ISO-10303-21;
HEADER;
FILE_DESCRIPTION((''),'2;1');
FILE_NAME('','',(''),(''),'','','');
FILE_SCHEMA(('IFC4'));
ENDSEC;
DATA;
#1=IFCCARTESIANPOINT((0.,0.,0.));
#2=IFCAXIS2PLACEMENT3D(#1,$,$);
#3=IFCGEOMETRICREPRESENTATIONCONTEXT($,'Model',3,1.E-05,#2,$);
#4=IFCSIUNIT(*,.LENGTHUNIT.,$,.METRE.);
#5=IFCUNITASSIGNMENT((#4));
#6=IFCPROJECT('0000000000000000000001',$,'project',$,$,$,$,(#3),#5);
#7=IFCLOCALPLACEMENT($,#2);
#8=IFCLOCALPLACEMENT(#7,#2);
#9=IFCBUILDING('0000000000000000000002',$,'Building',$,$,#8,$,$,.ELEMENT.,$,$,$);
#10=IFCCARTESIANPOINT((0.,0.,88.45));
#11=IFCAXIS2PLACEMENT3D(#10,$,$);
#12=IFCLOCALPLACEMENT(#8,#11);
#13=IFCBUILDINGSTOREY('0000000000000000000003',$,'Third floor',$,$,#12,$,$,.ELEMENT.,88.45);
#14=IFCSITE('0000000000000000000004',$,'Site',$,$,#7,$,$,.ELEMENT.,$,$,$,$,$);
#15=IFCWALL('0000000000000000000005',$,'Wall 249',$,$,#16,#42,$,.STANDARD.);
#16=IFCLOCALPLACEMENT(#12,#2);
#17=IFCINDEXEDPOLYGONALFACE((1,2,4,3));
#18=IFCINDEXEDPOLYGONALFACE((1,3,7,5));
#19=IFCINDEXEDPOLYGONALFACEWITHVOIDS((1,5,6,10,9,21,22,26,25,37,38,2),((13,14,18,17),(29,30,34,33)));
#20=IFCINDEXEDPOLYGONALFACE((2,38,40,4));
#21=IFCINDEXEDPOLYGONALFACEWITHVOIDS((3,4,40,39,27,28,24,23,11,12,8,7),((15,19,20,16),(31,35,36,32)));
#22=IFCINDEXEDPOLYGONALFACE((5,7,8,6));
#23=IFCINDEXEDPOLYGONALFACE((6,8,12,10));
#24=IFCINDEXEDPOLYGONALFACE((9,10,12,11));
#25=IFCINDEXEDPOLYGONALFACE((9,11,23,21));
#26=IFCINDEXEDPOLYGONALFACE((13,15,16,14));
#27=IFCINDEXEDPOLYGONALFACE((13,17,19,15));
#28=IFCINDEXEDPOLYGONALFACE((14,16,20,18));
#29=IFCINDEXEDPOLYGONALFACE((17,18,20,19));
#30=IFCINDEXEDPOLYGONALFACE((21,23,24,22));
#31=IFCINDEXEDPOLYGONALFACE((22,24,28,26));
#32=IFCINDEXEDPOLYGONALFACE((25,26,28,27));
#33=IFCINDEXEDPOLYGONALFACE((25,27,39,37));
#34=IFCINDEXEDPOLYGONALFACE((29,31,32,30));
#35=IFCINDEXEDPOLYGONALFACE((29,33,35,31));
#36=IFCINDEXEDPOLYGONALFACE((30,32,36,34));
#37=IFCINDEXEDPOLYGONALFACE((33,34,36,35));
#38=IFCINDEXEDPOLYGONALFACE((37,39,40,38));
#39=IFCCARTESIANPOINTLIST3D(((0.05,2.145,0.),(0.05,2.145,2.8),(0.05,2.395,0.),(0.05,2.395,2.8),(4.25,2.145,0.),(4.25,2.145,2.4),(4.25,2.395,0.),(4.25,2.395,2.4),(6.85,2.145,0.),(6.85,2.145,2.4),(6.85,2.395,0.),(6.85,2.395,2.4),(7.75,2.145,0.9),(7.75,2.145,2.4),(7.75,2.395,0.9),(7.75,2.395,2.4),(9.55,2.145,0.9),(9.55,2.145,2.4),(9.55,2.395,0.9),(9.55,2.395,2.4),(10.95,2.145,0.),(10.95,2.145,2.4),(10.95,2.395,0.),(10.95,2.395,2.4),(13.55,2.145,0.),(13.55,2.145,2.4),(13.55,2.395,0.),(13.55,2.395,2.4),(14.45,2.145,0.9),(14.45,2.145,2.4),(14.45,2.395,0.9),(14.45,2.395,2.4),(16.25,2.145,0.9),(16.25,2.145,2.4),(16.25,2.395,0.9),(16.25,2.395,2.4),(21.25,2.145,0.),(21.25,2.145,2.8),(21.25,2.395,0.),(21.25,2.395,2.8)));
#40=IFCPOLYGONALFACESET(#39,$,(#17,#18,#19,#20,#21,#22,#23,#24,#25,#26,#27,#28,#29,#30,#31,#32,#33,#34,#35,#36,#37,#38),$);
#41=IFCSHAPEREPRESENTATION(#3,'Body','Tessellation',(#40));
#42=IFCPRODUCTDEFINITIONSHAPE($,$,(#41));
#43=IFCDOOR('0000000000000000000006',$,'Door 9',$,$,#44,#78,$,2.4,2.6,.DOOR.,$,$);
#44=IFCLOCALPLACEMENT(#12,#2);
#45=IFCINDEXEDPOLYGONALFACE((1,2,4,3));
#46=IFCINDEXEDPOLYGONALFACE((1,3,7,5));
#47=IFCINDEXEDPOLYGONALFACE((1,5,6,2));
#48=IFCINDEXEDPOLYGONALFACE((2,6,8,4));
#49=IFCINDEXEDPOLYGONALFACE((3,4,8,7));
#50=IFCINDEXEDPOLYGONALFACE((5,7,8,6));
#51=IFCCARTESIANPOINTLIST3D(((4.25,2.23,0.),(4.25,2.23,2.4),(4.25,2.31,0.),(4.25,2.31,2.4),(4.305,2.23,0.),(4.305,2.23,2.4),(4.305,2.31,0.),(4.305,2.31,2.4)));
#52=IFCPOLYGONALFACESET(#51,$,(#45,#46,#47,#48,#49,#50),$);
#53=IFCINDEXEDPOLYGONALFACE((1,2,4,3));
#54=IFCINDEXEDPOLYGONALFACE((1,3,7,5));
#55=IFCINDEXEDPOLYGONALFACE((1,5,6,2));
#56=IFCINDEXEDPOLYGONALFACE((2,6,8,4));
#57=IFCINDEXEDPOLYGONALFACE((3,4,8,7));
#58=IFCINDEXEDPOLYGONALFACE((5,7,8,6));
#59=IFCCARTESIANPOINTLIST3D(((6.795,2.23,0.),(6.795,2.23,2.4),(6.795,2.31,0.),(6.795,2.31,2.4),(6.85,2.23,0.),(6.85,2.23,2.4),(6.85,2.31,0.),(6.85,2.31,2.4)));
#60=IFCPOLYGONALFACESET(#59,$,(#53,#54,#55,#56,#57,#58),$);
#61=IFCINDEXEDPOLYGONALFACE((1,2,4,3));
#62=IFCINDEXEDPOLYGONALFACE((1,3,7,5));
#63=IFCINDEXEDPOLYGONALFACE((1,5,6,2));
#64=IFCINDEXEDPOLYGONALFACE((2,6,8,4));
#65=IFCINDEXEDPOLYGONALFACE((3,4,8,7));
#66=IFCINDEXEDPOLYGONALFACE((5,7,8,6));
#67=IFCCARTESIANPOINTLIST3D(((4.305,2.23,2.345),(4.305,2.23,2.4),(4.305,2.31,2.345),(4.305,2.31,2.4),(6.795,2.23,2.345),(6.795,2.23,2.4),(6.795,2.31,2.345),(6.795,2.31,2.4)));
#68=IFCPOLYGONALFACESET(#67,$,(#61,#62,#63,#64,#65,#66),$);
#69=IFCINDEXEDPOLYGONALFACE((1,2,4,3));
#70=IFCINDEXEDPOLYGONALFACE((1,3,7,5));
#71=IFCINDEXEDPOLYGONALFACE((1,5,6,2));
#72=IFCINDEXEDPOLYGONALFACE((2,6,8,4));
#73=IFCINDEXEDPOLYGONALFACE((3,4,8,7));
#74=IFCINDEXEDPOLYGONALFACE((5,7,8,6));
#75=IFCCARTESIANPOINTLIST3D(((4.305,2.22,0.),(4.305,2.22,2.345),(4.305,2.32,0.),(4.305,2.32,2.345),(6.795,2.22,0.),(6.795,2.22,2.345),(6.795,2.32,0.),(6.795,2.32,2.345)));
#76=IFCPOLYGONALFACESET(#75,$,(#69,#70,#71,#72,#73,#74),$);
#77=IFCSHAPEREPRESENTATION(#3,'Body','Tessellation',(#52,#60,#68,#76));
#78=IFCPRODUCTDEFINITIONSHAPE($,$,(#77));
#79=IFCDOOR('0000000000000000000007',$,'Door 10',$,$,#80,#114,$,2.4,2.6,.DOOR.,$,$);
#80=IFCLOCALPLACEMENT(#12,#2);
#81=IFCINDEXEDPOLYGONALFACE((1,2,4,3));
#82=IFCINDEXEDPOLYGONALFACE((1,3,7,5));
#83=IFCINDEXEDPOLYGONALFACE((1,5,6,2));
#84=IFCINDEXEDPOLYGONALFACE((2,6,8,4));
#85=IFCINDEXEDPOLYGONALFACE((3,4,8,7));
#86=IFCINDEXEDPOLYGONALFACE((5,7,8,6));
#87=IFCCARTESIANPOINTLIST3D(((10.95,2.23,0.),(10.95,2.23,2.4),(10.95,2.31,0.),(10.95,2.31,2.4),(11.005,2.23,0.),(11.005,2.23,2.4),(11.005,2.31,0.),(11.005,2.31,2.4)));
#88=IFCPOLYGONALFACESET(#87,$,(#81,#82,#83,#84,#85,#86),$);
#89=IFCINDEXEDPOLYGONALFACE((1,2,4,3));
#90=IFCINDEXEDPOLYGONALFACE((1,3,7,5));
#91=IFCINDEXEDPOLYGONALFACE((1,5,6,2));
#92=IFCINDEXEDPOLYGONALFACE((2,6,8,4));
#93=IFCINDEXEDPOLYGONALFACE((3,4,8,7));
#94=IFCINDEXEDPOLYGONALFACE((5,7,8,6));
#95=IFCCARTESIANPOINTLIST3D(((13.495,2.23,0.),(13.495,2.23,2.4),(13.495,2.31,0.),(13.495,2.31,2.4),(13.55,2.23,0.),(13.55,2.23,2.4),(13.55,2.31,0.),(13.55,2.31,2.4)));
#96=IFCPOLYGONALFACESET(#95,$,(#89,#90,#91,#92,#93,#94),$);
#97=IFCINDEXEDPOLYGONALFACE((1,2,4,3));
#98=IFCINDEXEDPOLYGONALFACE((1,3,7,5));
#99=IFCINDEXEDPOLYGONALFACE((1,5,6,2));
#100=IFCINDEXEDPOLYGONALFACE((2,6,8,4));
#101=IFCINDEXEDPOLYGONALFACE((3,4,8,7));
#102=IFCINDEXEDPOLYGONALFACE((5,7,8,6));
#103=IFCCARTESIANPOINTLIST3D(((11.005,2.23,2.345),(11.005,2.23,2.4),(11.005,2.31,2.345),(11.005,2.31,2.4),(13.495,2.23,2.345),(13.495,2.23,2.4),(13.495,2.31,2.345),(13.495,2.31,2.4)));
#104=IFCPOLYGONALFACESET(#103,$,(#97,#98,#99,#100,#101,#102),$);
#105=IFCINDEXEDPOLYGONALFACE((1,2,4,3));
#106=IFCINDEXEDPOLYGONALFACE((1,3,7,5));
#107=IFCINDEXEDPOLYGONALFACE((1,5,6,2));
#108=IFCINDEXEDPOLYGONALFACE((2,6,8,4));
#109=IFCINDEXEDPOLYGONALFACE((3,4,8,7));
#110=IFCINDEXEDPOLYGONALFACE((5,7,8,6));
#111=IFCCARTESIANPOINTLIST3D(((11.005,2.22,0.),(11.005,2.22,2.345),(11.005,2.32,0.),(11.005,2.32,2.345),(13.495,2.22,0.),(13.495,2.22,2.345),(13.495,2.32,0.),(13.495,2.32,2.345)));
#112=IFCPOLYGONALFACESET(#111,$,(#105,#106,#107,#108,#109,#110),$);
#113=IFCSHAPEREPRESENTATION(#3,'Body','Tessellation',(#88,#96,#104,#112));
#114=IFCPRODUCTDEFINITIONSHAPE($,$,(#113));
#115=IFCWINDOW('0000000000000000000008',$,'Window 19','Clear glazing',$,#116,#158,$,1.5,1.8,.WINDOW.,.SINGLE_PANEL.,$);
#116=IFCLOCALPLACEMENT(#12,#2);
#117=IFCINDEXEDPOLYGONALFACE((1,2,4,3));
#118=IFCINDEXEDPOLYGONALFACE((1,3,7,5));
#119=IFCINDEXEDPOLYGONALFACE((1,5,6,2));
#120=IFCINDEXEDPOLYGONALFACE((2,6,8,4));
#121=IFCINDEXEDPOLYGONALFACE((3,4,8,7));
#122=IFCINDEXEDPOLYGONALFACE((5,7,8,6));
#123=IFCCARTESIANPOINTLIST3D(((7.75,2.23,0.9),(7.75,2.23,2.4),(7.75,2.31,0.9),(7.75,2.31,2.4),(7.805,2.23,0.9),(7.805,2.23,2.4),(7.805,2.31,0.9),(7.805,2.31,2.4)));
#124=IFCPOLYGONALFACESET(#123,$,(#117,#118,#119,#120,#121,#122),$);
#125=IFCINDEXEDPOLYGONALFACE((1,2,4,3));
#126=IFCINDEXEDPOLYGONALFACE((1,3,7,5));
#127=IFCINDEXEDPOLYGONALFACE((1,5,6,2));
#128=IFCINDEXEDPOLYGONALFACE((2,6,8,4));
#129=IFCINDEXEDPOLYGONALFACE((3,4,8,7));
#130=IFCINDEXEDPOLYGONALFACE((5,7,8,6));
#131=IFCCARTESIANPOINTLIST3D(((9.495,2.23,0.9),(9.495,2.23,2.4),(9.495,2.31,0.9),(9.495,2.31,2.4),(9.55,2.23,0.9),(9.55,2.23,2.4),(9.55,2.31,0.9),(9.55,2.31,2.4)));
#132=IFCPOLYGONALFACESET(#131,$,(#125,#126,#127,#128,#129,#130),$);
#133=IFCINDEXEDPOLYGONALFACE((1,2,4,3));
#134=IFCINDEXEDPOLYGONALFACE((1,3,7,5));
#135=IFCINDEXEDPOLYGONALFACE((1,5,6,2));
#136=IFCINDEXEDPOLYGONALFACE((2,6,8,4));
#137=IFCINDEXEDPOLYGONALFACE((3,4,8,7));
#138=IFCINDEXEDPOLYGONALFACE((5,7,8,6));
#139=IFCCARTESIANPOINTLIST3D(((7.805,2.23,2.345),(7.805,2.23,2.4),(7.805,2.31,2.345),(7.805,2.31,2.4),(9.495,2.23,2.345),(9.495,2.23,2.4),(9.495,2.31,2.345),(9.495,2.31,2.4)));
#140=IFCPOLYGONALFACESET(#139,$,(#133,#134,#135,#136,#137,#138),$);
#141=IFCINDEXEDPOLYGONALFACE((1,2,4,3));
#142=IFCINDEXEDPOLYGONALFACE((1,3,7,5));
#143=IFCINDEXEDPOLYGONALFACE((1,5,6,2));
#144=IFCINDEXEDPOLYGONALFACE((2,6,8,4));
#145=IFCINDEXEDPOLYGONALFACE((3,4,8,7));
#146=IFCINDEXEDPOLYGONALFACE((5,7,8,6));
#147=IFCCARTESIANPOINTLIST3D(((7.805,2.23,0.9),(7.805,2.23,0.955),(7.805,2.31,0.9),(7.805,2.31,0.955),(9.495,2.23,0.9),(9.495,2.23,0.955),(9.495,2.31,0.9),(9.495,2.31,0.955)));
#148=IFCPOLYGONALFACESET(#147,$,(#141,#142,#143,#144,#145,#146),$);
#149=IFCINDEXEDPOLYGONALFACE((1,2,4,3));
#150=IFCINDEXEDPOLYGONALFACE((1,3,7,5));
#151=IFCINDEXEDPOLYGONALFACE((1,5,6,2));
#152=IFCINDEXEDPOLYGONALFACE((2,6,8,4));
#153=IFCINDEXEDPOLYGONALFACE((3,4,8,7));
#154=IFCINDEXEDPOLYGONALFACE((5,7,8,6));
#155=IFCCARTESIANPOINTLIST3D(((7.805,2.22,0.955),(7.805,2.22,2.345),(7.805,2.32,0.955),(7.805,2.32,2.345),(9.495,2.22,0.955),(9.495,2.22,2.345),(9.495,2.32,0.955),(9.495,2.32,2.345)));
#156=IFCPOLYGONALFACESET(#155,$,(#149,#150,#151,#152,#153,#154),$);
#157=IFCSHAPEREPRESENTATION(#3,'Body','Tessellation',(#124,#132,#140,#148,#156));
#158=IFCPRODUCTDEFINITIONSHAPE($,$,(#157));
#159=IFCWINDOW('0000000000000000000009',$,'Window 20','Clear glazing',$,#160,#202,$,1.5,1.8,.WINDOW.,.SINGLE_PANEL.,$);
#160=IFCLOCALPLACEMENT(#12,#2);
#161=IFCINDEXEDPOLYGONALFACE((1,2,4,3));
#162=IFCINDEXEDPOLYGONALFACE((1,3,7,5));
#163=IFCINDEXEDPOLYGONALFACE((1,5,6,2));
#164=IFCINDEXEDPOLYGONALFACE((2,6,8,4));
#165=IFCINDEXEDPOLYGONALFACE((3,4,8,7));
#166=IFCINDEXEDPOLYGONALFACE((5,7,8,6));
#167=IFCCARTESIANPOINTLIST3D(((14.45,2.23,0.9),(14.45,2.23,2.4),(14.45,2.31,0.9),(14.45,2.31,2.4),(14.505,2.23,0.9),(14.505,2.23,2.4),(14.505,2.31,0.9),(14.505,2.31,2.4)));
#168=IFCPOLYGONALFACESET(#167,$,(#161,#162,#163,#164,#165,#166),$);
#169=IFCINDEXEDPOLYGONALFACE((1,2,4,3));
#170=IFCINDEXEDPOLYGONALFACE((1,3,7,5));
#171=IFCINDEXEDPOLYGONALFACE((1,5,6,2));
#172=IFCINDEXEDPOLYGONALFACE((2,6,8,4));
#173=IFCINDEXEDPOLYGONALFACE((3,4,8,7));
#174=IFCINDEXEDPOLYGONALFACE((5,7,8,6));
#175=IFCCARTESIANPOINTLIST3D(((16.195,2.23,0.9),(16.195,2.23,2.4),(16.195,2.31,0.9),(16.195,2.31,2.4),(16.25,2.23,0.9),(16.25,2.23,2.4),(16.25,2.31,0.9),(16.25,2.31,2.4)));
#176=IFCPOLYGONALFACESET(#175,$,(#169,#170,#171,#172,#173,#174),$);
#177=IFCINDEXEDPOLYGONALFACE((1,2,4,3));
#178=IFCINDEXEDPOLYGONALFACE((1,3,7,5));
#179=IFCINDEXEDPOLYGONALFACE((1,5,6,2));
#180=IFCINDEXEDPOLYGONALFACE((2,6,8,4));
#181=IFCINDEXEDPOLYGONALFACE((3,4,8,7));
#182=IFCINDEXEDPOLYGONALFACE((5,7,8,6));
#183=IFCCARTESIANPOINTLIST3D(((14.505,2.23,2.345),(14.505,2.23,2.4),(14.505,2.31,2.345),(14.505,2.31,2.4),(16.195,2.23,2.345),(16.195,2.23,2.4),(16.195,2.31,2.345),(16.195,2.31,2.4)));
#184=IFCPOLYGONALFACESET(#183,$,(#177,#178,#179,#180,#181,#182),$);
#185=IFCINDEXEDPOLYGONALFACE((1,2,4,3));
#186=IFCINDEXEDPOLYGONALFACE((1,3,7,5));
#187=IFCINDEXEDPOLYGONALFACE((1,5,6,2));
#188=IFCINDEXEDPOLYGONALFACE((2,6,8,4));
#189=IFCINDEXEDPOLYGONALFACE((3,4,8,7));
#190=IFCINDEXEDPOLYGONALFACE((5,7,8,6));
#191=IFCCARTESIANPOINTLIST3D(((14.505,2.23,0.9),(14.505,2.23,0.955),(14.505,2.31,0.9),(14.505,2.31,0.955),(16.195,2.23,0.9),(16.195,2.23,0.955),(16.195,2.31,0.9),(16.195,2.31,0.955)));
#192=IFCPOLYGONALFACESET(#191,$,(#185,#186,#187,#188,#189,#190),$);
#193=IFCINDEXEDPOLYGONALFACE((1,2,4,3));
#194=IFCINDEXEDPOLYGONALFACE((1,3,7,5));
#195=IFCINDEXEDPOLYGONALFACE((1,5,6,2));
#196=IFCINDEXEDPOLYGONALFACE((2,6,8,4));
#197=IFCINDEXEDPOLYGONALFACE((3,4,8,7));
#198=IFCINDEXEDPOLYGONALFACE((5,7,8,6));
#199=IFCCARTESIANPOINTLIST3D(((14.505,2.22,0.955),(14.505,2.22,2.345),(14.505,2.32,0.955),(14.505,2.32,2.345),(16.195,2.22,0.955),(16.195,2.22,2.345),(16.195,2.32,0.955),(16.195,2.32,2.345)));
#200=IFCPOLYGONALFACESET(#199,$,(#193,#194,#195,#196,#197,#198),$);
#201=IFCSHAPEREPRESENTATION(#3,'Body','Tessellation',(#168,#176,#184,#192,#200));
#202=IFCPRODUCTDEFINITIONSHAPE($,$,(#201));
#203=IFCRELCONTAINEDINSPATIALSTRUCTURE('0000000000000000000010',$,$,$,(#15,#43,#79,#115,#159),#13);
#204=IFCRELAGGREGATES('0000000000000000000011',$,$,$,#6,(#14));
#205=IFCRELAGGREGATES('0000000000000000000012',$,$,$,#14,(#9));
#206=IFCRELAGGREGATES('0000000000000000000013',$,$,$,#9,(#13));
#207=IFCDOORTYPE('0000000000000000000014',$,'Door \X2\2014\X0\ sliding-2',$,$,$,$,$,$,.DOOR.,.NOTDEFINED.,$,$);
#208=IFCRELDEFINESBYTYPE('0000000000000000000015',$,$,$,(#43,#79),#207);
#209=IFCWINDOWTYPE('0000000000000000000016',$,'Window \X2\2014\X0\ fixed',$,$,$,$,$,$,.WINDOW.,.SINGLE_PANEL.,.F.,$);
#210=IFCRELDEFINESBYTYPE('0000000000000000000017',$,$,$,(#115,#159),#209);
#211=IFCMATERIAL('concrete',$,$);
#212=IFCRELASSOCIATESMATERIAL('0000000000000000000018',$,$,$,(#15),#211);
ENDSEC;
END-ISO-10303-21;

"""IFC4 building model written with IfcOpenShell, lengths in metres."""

from ifc_helpers import new_model, si_unit, frame, frame_2d, origin, place, context, project, spatial, rectangle, extrude, material, type_object, element, fill, save


model = new_model("IFC4")

# Units and contexts
model_context = context("Model", 3, precision=1e-05, world=origin())
ifc_project = project(units=[si_unit("LENGTHUNIT", "METRE")], contexts=[model_context])

# Site, building, storey
site_placement = place(None, origin())
site = spatial("IfcSite", under=ifc_project, at=site_placement, Name="Site", CompositionType="ELEMENT")
building_placement = place(site_placement, origin())
building = spatial("IfcBuilding", under=site, at=building_placement, Name="Building", CompositionType="ELEMENT")
storey_placement = place(building_placement, frame((0.0, 0.0, 88.45)))
storey = spatial("IfcBuildingStorey", under=building, at=storey_placement, Name="Third floor", CompositionType="ELEMENT", Elevation=88.45)

# Shared definitions
ifc_material = material(Name="concrete")

# Wall, openings, doors, windows
wall_1_placement = place(storey_placement, frame((0.05, 2.27, 0.0), z_axis=(0.0, 0.0, 1.0), x_axis=(1.0, 0.0, 0.0)))
wall_1 = element("IfcWall", 1, at=wall_1_placement, inside=storey, material=ifc_material, Name="Wall 249", PredefinedType="STANDARD", context=model_context, shape_type="SweptSolid", body=[
    extrude(rectangle(XDim=21.2, YDim=0.25, at=frame_2d((10.6, 0.0))), origin(), (0.0, 0.0, 1.0), 2.8),
])
opening_1_placement = place(storey_placement, frame((4.25, 2.27, 0.0), z_axis=(0.0, 0.0, 1.0), x_axis=(1.0, 0.0, 0.0)))
opening_1 = element("IfcOpeningElement", 2, at=opening_1_placement, cuts=wall_1, PredefinedType="OPENING", context=model_context, shape_type="SweptSolid", body=[
    extrude(rectangle(XDim=2.6, YDim=0.31, at=frame_2d((1.3, 0.0))), origin(), (0.0, 0.0, 1.0), 2.4),
])
opening_2_placement = place(storey_placement, frame((7.75, 2.27, 0.9), z_axis=(0.0, 0.0, 1.0), x_axis=(1.0, 0.0, 0.0)))
opening_2 = element("IfcOpeningElement", 3, at=opening_2_placement, cuts=wall_1, PredefinedType="OPENING", context=model_context, shape_type="SweptSolid", body=[
    extrude(rectangle(XDim=1.8, YDim=0.31, at=frame_2d((0.9, 0.0))), origin(), (0.0, 0.0, 1.0), 1.5),
])
opening_3_placement = place(storey_placement, frame((10.95, 2.27, 0.0), z_axis=(0.0, 0.0, 1.0), x_axis=(1.0, 0.0, 0.0)))
opening_3 = element("IfcOpeningElement", 4, at=opening_3_placement, cuts=wall_1, PredefinedType="OPENING", context=model_context, shape_type="SweptSolid", body=[
    extrude(rectangle(XDim=2.6, YDim=0.31, at=frame_2d((1.3, 0.0))), origin(), (0.0, 0.0, 1.0), 2.4),
])
opening_4_placement = place(storey_placement, frame((14.45, 2.27, 0.9), z_axis=(0.0, 0.0, 1.0), x_axis=(1.0, 0.0, 0.0)))
opening_4 = element("IfcOpeningElement", 5, at=opening_4_placement, cuts=wall_1, PredefinedType="OPENING", context=model_context, shape_type="SweptSolid", body=[
    extrude(rectangle(XDim=1.8, YDim=0.31, at=frame_2d((0.9, 0.0))), origin(), (0.0, 0.0, 1.0), 1.5),
])
door_type = type_object("IfcDoorType", Name="Door — sliding-2", PredefinedType="DOOR")
door_1_placement = place(storey_placement, frame((4.25, 2.27, 0.0), z_axis=(0.0, 0.0, 1.0), x_axis=(1.0, 0.0, 0.0)))
door_1 = element("IfcDoor", 6, at=door_1_placement, inside=storey, type_object=door_type, Name="Door 9", OverallHeight=2.4, OverallWidth=2.6, PredefinedType="DOOR", context=model_context, shape_type="SweptSolid", body=[
    extrude(rectangle(XDim=0.055, YDim=0.08, at=frame_2d((0.0275, 0.0))), origin(), (0.0, 0.0, 1.0), 2.4),
    extrude(rectangle(XDim=0.055, YDim=0.08, at=frame_2d((2.5725, 0.0))), origin(), (0.0, 0.0, 1.0), 2.4),
    extrude(rectangle(XDim=2.49, YDim=0.08, at=frame_2d((1.3, 0.0))), frame((0.0, 0.0, 2.345)), (0.0, 0.0, 1.0), 0.055),
    extrude(rectangle(XDim=2.49, YDim=0.1, at=frame_2d((1.3, 0.0))), origin(), (0.0, 0.0, 1.0), 2.345),
])
fill(opening_1, door_1)
door_2_placement = place(storey_placement, frame((10.95, 2.27, 0.0), z_axis=(0.0, 0.0, 1.0), x_axis=(1.0, 0.0, 0.0)))
door_2 = element("IfcDoor", 7, at=door_2_placement, inside=storey, type_object=door_type, Name="Door 10", OverallHeight=2.4, OverallWidth=2.6, PredefinedType="DOOR", context=model_context, shape_type="SweptSolid", body=[
    extrude(rectangle(XDim=0.055, YDim=0.08, at=frame_2d((0.0275, 0.0))), origin(), (0.0, 0.0, 1.0), 2.4),
    extrude(rectangle(XDim=0.055, YDim=0.08, at=frame_2d((2.5725, 0.0))), origin(), (0.0, 0.0, 1.0), 2.4),
    extrude(rectangle(XDim=2.49, YDim=0.08, at=frame_2d((1.3, 0.0))), frame((0.0, 0.0, 2.345)), (0.0, 0.0, 1.0), 0.055),
    extrude(rectangle(XDim=2.49, YDim=0.1, at=frame_2d((1.3, 0.0))), origin(), (0.0, 0.0, 1.0), 2.345),
])
fill(opening_3, door_2)
window_type = type_object("IfcWindowType", Name="Window — fixed", ParameterTakesPrecedence=False, PartitioningType="SINGLE_PANEL", PredefinedType="WINDOW")
window_1_placement = place(storey_placement, frame((7.75, 2.27, 0.9), z_axis=(0.0, 0.0, 1.0), x_axis=(1.0, 0.0, 0.0)))
window_1 = element("IfcWindow", 8, at=window_1_placement, inside=storey, type_object=window_type, Name="Window 19", Description="Clear glazing", OverallHeight=1.5, OverallWidth=1.8, PartitioningType="SINGLE_PANEL", PredefinedType="WINDOW", context=model_context, shape_type="SweptSolid", body=[
    extrude(rectangle(XDim=0.055, YDim=0.08, at=frame_2d((0.0275, 0.0))), origin(), (0.0, 0.0, 1.0), 1.5),
    extrude(rectangle(XDim=0.055, YDim=0.08, at=frame_2d((1.7725, 0.0))), origin(), (0.0, 0.0, 1.0), 1.5),
    extrude(rectangle(XDim=1.69, YDim=0.08, at=frame_2d((0.9, 0.0))), frame((0.0, 0.0, 1.445)), (0.0, 0.0, 1.0), 0.055),
    extrude(rectangle(XDim=1.69, YDim=0.08, at=frame_2d((0.9, 0.0))), origin(), (0.0, 0.0, 1.0), 0.055),
    extrude(rectangle(XDim=1.69, YDim=0.1, at=frame_2d((0.9, 0.0))), frame((0.0, 0.0, 0.055)), (0.0, 0.0, 1.0), 1.39),
])
fill(opening_2, window_1)
window_2_placement = place(storey_placement, frame((14.45, 2.27, 0.9), z_axis=(0.0, 0.0, 1.0), x_axis=(1.0, 0.0, 0.0)))
window_2 = element("IfcWindow", 9, at=window_2_placement, inside=storey, type_object=window_type, Name="Window 20", Description="Clear glazing", OverallHeight=1.5, OverallWidth=1.8, PartitioningType="SINGLE_PANEL", PredefinedType="WINDOW", context=model_context, shape_type="SweptSolid", body=[
    extrude(rectangle(XDim=0.055, YDim=0.08, at=frame_2d((0.0275, 0.0))), origin(), (0.0, 0.0, 1.0), 1.5),
    extrude(rectangle(XDim=0.055, YDim=0.08, at=frame_2d((1.7725, 0.0))), origin(), (0.0, 0.0, 1.0), 1.5),
    extrude(rectangle(XDim=1.69, YDim=0.08, at=frame_2d((0.9, 0.0))), frame((0.0, 0.0, 1.445)), (0.0, 0.0, 1.0), 0.055),
    extrude(rectangle(XDim=1.69, YDim=0.08, at=frame_2d((0.9, 0.0))), origin(), (0.0, 0.0, 1.0), 0.055),
    extrude(rectangle(XDim=1.69, YDim=0.1, at=frame_2d((0.9, 0.0))), frame((0.0, 0.0, 0.055)), (0.0, 0.0, 1.0), 1.39),
])
fill(opening_4, window_2)

save(model, "model.ifc")
